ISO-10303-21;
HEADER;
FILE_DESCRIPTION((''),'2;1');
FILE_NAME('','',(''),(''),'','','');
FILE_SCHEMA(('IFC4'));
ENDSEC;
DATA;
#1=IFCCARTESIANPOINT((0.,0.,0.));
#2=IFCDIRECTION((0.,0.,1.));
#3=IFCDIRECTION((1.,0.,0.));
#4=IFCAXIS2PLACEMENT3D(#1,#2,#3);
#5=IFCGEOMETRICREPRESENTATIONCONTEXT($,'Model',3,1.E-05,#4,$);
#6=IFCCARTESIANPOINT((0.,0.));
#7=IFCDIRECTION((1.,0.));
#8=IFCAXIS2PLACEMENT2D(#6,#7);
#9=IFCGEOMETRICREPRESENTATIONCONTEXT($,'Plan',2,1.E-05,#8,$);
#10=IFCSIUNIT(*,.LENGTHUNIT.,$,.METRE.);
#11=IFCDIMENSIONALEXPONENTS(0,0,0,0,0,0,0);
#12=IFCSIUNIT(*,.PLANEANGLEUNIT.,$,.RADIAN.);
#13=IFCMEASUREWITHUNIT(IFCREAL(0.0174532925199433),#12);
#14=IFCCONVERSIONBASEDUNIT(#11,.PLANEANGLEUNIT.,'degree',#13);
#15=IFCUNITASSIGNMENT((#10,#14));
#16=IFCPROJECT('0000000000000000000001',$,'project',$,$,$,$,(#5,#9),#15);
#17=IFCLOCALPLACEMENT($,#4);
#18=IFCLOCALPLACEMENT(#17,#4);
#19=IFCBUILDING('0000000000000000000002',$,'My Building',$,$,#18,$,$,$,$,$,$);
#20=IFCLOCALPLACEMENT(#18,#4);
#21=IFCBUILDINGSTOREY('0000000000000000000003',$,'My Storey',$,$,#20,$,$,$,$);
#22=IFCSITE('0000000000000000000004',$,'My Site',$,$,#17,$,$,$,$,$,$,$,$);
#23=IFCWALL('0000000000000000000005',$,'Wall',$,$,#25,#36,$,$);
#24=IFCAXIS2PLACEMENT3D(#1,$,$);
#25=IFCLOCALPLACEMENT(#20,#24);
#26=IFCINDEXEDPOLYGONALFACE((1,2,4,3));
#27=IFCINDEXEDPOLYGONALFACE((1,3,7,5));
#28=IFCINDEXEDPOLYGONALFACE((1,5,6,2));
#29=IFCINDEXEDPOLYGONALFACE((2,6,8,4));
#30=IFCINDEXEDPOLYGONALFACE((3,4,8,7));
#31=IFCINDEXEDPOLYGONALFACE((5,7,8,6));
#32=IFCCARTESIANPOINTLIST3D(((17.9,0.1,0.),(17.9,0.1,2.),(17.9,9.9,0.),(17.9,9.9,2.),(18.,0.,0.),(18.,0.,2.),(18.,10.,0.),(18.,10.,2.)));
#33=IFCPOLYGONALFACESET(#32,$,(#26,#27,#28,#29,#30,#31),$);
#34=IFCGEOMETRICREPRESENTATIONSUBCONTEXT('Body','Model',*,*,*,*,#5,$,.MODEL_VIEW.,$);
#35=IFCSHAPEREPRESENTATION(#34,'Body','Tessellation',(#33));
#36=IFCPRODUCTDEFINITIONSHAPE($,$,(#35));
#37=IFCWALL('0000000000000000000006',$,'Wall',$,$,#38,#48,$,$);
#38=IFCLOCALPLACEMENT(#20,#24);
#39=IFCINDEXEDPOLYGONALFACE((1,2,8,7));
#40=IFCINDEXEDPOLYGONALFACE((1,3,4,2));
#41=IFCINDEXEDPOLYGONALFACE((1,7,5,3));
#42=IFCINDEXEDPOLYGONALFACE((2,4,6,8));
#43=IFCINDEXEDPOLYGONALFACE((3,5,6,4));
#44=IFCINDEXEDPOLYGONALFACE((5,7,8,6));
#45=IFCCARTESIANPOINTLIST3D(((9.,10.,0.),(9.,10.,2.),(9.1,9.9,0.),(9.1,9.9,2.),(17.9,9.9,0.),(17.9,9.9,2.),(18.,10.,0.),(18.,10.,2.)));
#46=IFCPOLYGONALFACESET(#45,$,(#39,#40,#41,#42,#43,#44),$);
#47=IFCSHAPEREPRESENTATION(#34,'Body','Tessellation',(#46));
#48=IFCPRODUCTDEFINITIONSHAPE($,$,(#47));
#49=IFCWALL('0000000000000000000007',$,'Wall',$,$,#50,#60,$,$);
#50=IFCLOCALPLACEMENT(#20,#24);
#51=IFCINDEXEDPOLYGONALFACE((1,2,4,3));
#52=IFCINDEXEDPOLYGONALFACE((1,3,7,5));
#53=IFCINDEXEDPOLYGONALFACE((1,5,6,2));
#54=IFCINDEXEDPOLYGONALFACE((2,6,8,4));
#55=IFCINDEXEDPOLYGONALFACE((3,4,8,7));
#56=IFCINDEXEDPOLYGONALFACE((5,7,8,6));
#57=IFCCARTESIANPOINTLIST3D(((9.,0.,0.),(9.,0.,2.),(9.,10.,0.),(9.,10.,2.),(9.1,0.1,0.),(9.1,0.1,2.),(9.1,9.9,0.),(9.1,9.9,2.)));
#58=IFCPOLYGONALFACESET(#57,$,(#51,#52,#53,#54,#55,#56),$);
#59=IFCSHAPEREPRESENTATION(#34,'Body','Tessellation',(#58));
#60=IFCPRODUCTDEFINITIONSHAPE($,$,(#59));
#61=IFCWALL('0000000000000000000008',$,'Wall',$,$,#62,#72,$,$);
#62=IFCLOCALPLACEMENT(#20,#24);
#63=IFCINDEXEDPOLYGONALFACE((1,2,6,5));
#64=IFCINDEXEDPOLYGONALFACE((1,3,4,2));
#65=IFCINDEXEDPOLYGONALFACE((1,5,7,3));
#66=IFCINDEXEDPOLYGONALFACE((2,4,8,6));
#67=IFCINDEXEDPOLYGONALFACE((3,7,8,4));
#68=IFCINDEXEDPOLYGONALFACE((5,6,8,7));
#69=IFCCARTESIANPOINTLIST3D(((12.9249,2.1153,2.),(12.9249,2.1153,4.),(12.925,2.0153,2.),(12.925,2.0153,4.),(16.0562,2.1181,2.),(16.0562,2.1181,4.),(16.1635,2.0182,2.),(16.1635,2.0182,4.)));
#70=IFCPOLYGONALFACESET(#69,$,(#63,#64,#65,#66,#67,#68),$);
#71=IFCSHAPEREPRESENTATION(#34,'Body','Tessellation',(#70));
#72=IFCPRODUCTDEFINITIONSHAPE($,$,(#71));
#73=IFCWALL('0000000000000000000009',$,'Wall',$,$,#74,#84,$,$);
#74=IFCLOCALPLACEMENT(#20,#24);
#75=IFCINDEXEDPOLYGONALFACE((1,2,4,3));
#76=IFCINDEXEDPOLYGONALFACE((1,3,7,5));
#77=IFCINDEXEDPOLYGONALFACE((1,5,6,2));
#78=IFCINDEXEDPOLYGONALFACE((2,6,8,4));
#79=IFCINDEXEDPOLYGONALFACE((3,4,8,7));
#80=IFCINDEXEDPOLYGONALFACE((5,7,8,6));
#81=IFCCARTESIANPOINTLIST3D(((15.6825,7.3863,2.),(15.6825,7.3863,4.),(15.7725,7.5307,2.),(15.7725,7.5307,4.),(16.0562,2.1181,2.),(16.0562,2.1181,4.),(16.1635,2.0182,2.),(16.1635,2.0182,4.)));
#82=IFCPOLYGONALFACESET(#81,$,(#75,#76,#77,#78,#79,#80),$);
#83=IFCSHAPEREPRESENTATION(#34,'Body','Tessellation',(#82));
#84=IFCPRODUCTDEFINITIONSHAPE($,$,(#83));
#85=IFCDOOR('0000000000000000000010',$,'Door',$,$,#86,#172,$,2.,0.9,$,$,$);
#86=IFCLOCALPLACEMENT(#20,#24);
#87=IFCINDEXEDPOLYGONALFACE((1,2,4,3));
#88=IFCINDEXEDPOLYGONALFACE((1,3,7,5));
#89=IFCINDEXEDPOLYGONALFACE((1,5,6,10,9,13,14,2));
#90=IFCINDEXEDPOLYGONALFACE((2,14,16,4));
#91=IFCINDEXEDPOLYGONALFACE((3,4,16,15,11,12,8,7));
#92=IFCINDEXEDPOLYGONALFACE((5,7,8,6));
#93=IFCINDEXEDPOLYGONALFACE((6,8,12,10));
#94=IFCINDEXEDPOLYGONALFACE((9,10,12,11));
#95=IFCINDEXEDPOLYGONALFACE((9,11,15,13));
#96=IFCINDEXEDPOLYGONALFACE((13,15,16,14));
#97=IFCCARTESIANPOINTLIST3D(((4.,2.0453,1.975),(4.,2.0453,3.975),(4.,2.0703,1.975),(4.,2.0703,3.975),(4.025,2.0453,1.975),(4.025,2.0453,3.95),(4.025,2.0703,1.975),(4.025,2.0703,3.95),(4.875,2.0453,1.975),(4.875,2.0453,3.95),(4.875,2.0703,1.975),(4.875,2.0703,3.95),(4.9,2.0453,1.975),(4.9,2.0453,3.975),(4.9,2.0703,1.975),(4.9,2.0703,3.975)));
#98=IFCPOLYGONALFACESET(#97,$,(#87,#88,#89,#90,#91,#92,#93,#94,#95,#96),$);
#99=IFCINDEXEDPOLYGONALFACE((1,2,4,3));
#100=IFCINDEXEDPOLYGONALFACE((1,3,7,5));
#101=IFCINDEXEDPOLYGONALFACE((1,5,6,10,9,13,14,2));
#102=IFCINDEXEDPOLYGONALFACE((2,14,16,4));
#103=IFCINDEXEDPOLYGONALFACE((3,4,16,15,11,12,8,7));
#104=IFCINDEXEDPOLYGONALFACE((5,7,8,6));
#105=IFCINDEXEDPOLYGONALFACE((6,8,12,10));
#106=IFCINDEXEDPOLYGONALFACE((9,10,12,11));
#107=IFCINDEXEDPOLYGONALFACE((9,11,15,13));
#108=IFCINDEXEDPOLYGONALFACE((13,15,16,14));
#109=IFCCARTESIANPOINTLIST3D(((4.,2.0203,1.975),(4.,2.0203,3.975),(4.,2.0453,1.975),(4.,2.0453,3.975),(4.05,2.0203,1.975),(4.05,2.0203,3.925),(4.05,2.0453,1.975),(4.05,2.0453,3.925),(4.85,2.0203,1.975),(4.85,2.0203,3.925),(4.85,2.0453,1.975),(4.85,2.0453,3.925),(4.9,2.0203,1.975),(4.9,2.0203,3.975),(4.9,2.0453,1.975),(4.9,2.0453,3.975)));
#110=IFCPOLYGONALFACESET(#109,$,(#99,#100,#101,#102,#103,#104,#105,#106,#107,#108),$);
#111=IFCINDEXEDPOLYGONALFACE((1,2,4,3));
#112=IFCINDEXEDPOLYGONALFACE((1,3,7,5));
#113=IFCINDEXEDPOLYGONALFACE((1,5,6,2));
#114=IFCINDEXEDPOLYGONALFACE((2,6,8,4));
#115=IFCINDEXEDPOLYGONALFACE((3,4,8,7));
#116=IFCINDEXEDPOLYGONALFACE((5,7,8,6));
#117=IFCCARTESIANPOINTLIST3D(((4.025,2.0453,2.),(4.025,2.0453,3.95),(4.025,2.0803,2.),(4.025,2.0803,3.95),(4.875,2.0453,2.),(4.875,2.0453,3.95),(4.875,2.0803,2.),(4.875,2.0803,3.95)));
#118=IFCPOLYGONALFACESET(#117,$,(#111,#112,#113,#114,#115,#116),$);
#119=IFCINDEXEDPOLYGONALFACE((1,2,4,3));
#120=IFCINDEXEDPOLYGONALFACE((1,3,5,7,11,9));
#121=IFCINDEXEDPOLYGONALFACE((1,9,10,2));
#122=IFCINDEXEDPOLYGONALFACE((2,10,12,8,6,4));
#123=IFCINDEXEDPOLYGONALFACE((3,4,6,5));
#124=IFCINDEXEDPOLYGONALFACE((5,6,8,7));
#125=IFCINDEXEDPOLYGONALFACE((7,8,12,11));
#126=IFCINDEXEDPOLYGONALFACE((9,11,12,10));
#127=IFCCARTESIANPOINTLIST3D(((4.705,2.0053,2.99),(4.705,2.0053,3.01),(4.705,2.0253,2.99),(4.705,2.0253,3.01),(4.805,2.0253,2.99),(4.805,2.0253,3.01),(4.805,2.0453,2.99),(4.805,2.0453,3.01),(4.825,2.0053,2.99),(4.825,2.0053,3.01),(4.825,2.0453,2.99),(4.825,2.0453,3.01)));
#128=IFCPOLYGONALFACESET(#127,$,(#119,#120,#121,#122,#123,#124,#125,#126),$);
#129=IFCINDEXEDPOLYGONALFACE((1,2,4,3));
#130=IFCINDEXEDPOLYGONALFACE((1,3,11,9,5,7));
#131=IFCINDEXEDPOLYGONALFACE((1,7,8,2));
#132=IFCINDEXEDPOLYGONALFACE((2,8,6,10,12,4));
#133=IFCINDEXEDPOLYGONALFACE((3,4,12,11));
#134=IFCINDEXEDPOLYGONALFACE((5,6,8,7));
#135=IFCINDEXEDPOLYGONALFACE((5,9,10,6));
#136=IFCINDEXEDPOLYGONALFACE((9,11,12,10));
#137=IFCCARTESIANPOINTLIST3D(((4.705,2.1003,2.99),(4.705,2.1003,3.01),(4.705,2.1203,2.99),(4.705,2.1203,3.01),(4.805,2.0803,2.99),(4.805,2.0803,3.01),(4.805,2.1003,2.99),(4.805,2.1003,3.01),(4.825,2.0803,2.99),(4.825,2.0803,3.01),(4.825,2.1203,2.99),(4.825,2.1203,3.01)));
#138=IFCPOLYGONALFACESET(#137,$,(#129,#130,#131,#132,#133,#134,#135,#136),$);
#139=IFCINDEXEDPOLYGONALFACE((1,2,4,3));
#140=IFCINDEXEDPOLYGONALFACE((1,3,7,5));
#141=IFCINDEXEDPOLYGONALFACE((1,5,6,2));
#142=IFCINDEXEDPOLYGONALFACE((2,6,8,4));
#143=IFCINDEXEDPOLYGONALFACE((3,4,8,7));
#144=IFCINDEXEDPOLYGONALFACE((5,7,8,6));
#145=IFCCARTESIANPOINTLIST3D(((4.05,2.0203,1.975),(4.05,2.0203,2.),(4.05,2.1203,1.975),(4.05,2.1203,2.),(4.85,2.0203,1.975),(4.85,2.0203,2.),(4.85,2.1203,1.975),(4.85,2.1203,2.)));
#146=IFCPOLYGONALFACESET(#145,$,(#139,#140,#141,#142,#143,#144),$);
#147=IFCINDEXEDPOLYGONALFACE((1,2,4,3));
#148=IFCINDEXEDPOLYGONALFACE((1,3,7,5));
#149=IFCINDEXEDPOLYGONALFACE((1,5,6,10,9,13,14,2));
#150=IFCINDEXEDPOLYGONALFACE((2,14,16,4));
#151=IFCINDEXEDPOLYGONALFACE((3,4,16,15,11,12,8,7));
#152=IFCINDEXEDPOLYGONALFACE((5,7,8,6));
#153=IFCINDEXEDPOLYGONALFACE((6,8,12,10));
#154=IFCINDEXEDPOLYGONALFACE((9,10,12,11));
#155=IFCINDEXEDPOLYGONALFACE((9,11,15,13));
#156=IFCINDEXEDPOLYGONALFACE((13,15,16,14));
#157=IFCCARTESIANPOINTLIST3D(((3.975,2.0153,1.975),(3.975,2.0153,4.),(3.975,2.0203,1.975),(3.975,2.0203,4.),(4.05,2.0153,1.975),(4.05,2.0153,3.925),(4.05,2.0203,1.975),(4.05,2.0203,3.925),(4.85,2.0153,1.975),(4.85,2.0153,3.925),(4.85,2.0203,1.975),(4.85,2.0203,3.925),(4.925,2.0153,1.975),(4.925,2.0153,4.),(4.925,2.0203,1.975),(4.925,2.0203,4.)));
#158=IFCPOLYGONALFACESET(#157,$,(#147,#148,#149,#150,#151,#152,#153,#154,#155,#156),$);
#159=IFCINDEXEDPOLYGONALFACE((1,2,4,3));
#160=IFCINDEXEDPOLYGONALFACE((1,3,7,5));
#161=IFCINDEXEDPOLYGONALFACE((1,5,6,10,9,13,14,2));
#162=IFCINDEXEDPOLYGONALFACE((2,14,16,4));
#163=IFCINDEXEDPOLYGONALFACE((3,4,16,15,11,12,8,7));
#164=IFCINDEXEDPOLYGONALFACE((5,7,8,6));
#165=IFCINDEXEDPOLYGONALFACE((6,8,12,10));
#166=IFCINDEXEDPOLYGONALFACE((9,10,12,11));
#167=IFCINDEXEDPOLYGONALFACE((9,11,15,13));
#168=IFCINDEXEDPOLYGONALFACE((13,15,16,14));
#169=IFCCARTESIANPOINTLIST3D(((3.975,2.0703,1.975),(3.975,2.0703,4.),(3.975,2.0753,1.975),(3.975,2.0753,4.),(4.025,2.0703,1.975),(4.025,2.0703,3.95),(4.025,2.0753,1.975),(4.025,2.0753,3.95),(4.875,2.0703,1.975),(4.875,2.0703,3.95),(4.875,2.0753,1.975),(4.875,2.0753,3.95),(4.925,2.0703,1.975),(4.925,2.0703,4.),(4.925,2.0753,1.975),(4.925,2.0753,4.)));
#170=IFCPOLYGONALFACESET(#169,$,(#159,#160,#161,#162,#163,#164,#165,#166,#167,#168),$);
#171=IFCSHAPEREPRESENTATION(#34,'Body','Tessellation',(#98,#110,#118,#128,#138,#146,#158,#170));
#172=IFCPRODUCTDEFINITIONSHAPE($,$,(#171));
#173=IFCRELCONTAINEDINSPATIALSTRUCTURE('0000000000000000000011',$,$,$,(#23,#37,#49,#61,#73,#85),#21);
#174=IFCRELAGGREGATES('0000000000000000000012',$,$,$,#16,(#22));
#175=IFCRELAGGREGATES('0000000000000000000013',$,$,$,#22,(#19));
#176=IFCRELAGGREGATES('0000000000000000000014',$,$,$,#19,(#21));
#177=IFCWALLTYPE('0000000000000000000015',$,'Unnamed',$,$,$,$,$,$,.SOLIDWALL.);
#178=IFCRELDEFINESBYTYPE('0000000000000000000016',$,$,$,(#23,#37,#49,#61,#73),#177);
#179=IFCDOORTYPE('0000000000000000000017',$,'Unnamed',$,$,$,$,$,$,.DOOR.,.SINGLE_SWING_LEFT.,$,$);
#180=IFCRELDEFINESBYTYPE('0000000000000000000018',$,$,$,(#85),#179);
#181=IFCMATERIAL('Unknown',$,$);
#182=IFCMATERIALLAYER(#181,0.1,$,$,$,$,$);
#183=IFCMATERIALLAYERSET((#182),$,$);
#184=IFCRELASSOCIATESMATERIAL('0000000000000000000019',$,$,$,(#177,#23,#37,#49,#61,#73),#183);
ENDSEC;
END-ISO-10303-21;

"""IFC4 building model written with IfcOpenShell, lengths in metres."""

from ifc_helpers import new_model, entity, si_unit, converted_unit, frame, origin_with_axes, origin_2d_with_axis, place, context, subcontext, project, spatial, line, indexed_curve, outline, extrude, clip, halfspace, shape, source, transform, mapped, material, layer, layer_set, layer_usage, type_object, type_shapes, element, save


model = new_model("IFC4")

# Units and contexts
model_context = context("Model", 3, precision=1e-05, world=origin_with_axes())
plan_context = context("Plan", 2, precision=1e-05, world=origin_2d_with_axis())
body_context_1 = subcontext(model_context, "Body", "Model", "MODEL_VIEW")
body_context_2 = subcontext(plan_context, "Body", "Plan", "PLAN_VIEW")
ifc_project = project(units=[si_unit("LENGTHUNIT", "METRE"), converted_unit("PLANEANGLEUNIT", "degree", entity("IfcReal", 0.0174532925199433), si_unit("PLANEANGLEUNIT", "RADIAN"), dimensions=[0, 0, 0, 0, 0, 0, 0])], contexts=[model_context, plan_context])

# Site, building, storey
site_placement = place(None, origin_with_axes())
site = spatial("IfcSite", under=ifc_project, at=site_placement, Name="My Site")
building_placement = place(site_placement, origin_with_axes())
building = spatial("IfcBuilding", under=site, at=building_placement, Name="My Building")
storey_placement = place(building_placement, origin_with_axes())
storey = spatial("IfcBuildingStorey", under=building, at=storey_placement, Name="My Storey")

# Shared definitions
ifc_material = material(Name="Unknown")

# Walls
ifc_layer_1 = layer(ifc_material, 0.1)
ifc_layer_set_1 = layer_set([ifc_layer_1])
wall_type = type_object("IfcWallType", Name="Unnamed", PredefinedType="SOLIDWALL", material=ifc_layer_set_1)
ifc_layer_usage_1 = layer_usage(ifc_layer_set_1, "AXIS2", "POSITIVE", 0.0)
wall_1_placement = place(storey_placement, frame((18.0, 0.0, 0.0), z_axis=(0.0, 0.0, 1.0), x_axis=(0.0, 1.0, 0.0)))
element("IfcWall", 1, at=wall_1_placement, inside=storey, type_object=wall_type, material=ifc_layer_usage_1, Name="Wall", context=body_context_1, shape_type="Clipping", body=[
    clip(clip(extrude(outline(indexed_curve([(0.0, 0.0), (0.0, 0.1), (10.0, 0.1), (10.0, 0.0), (0.0, 0.0)], self_intersect=False)), origin_with_axes(), (0.0, 0.0, 1.0), 2.0), halfspace(frame((10.0, 0.0, 0.0), z_axis=(0.707107, 0.707107, 0.0), x_axis=(0.707107, -0.707107, 0.0)), False)), halfspace(frame((0.0, 0.0, 0.0), z_axis=(-0.707108, 0.707105, 0.0), x_axis=(0.707105, 0.707108, 0.0)), False)),
])
ifc_layer_usage_2 = layer_usage(ifc_layer_set_1, "AXIS2", "POSITIVE", 0.0)
wall_2_placement = place(storey_placement, frame((18.0, 10.0, 0.0), z_axis=(0.0, 0.0, 1.0), x_axis=(-1.0, 0.0, 0.0)))
element("IfcWall", 2, at=wall_2_placement, inside=storey, type_object=wall_type, material=ifc_layer_usage_2, Name="Wall", context=body_context_1, shape_type="Clipping", body=[
    clip(clip(extrude(outline(indexed_curve([(0.0, 0.0), (0.0, 0.1), (9.0, 0.1), (9.0, 0.0), (0.0, 0.0)], self_intersect=False)), origin_with_axes(), (0.0, 0.0, 1.0), 2.0), halfspace(frame((9.0, 0.0, 0.0), z_axis=(0.707107, 0.707107, 0.0), x_axis=(0.707107, -0.707107, 0.0)), False)), halfspace(frame((0.0, 0.0, 0.0), z_axis=(-0.707107, 0.707107, 0.0), x_axis=(0.707107, 0.707107, 0.0)), False)),
])
ifc_layer_usage_3 = layer_usage(ifc_layer_set_1, "AXIS2", "POSITIVE", 0.0)
wall_3_placement = place(storey_placement, frame((9.0, 10.0, 0.0), z_axis=(0.0, 0.0, 1.0), x_axis=(0.0, -1.0, 0.0)))
element("IfcWall", 3, at=wall_3_placement, inside=storey, type_object=wall_type, material=ifc_layer_usage_3, Name="Wall", context=body_context_1, shape_type="Clipping", body=[
    clip(clip(extrude(outline(indexed_curve([(0.0, 0.0), (0.0, 0.1), (10.0, 0.1), (10.0, 0.0), (0.0, 0.0)], self_intersect=False)), origin_with_axes(), (0.0, 0.0, 1.0), 2.0), halfspace(frame((10.0, 0.0, 0.0), z_axis=(0.707108, 0.707105, 0.0), x_axis=(0.707105, -0.707108, 0.0)), False)), halfspace(frame((0.0, 0.0, 0.0), z_axis=(-0.707107, 0.707107, 0.0), x_axis=(0.707107, 0.707107, 0.0)), False)),
])
ifc_layer_usage_4 = layer_usage(ifc_layer_set_1, "AXIS2", "POSITIVE", 0.0)
wall_4_placement = place(storey_placement, frame((12.925, 2.0153, 2.0), z_axis=(0.0, 0.0, 1.0), x_axis=(1.0, 0.000878, 0.0)))
element("IfcWall", 4, at=wall_4_placement, inside=storey, type_object=wall_type, material=ifc_layer_usage_4, Name="Wall", context=body_context_1, shape_type="Clipping", body=[
    clip(extrude(outline(indexed_curve([(0.0, 0.0), (0.0, 0.1), (3.2385, 0.1), (3.2385, 0.0), (0.0, 0.0)], self_intersect=False)), origin_with_axes(), (0.0, 0.0, 1.0), 2.0), halfspace(frame((3.2385, 0.0, -2.0), z_axis=(0.681958, 0.731391, 0.0), x_axis=(0.731391, -0.681958, 0.0)), False)),
])
ifc_layer_usage_5 = layer_usage(ifc_layer_set_1, "AXIS2", "POSITIVE", 0.0)
wall_5_placement = place(storey_placement, frame((16.1635, 2.0182, 2.0), z_axis=(0.0, 0.0, 1.0), x_axis=(-0.070754, 0.997494, 0.0)))
element("IfcWall", 5, at=wall_5_placement, inside=storey, type_object=wall_type, material=ifc_layer_usage_5, Name="Wall", context=body_context_1, shape_type="Clipping", body=[
    clip(clip(extrude(outline(indexed_curve([(0.0, 0.0), (0.0, 0.1), (5.5264, 0.1), (5.5264, 0.0), (0.0, 0.0)], self_intersect=False)), origin_with_axes(), (0.0, 0.0, 1.0), 2.0), halfspace(frame((5.5264, 0.0, -2.0), z_axis=(0.587583, 0.809165, 0.0), x_axis=(0.809164, -0.587582, 0.0)), False)), halfspace(frame((0.0, 0.0, -2.0), z_axis=(-0.681949, 0.7314, 0.0), x_axis=(0.7314, 0.681949, 0.0)), False)),
])

# Door
door_type = type_object("IfcDoorType", Name="Unnamed", OperationType="SINGLE_SWING_LEFT", PredefinedType="DOOR")
shared_shape_1 = source(origin_with_axes(), body_context_1, "Body", "SolidModel", [
    extrude(outline(indexed_curve([(0.0, 0.0), (0.0, 2.0), (0.9, 2.0), (0.9, 0.0), (0.875, 0.0), (0.875, 1.975), (0.025, 1.975), (0.025, 0.0)], segments=[line(1, 2, 3, 4, 5, 6, 7, 8, 1)])), frame((0.0, 0.025, 0.0), z_axis=(0.0, -1.0, 0.0), x_axis=(1.0, 0.0, 0.0)), (0.0, 0.0, -1.0), 0.025),
    extrude(outline(indexed_curve([(0.0, 0.0), (0.0, 2.0), (0.9, 2.0), (0.9, 0.0), (0.85, 0.0), (0.85, 1.95), (0.05, 1.95), (0.05, 0.0)], segments=[line(1, 2, 3, 4, 5, 6, 7, 8, 1)])), frame((0.0, 0.0, 0.0), z_axis=(0.0, -1.0, 0.0), x_axis=(1.0, 0.0, 0.0)), (0.0, 0.0, -1.0), 0.025),
    extrude(outline(indexed_curve([(0.0, 0.0), (0.85, 0.0), (0.85, 0.035), (0.0, 0.035)], segments=[line(1, 2, 3, 4, 1)])), frame((0.025, 0.025, 0.025), z_axis=(0.0, 0.0, 1.0), x_axis=(1.0, 0.0, 0.0)), (0.0, 0.0, 1.0), 1.95),
    extrude(outline(indexed_curve([(0.0, 0.0), (0.0, -0.04), (-0.12, -0.04), (-0.12, -0.02), (-0.02, -0.02), (-0.02, 0.0)], segments=[line(1, 2, 3, 4, 5, 6, 1)])), frame((0.825, 0.025, 1.015), z_axis=(0.0, 0.0, 1.0), x_axis=(1.0, 0.0, 0.0)), (0.0, 0.0, 1.0), 0.02),
    extrude(outline(indexed_curve([(0.0, 0.0), (0.0, 0.04), (-0.12, 0.04), (-0.12, 0.02), (-0.02, 0.02), (-0.02, 0.0)], segments=[line(1, 2, 3, 4, 5, 6, 1)])), frame((0.825, 0.06, 1.015), z_axis=(0.0, 0.0, 1.0), x_axis=(1.0, 0.0, 0.0)), (0.0, 0.0, 1.0), 0.02),
    extrude(outline(indexed_curve([(0.0, 0.0), (0.8, 0.0), (0.8, 0.1), (0.0, 0.1)], segments=[line(1, 2, 3, 4, 1)])), frame((0.05, 0.0, 0.0), z_axis=(0.0, 0.0, 1.0), x_axis=(1.0, 0.0, 0.0)), (0.0, 0.0, 1.0), 0.025),
    extrude(outline(indexed_curve([(0.0, 0.0), (0.0, 2.025), (0.95, 2.025), (0.95, 0.0), (0.875, 0.0), (0.875, 1.95), (0.075, 1.95), (0.075, 0.0)], segments=[line(1, 2, 3, 4, 5, 6, 7, 8, 1)])), frame((-0.025, -0.005, 0.0), z_axis=(0.0, -1.0, 0.0), x_axis=(1.0, 0.0, 0.0)), (0.0, 0.0, -1.0), 0.005),
    extrude(outline(indexed_curve([(0.0, 0.0), (0.0, 2.025), (0.95, 2.025), (0.95, 0.0), (0.9, 0.0), (0.9, 1.975), (0.05, 1.975), (0.05, 0.0)], segments=[line(1, 2, 3, 4, 5, 6, 7, 8, 1)])), frame((-0.025, 0.05, 0.0), z_axis=(0.0, -1.0, 0.0), x_axis=(1.0, 0.0, 0.0)), (0.0, 0.0, -1.0), 0.005),
])
shared_shape_2 = source(origin_with_axes(), body_context_2, "Body", "Curve2D", [
    entity("IfcIndexedPolyCurve", entity("IfcCartesianPointList2D", [[0.0, 0.0], [0.0, 0.05], [0.025, 0.05], [0.025, 0.025], [0.05, 0.025], [0.05, 0.0]]), [entity("IfcLineIndex", [1, 2, 3, 4, 5, 6, 1])]),
    entity("IfcIndexedPolyCurve", entity("IfcCartesianPointList2D", [[0.9, 0.0], [0.9, 0.05], [0.875, 0.05], [0.875, 0.025], [0.85, 0.025], [0.85, 0.0]]), [entity("IfcLineIndex", [1, 2, 3, 4, 5, 6, 1])]),
    entity("IfcTrimmedCurve", entity("IfcEllipse", entity("IfcAxis2Placement2D", entity("IfcCartesianPoint", [0.06, 0.05]), entity("IfcDirection", [1.0, 0.0])), 0.815, 0.85), [entity("IfcCartesianPoint", [0.875, 0.05])], [entity("IfcCartesianPoint", [0.06, 0.9])], True, "CARTESIAN"),
    entity("IfcIndexedPolyCurve", entity("IfcCartesianPointList2D", [[0.025, 0.05], [0.06, 0.05], [0.06, 0.9], [0.025, 0.9]]), [entity("IfcLineIndex", [1, 2, 3, 4, 1])]),
])
type_shapes(door_type, [shared_shape_1, shared_shape_2])
for number, where, z_axis, x_axis, name in (
    (6, (4.0, 2.0203, 1.975), (0.0, 0.0, 1.0), (1.0, 0.0, 0.0), "Door"),
):
    element("IfcDoor", number, at=place(storey_placement, frame(where, z_axis=z_axis, x_axis=x_axis)), inside=storey, type_object=door_type, Name=name, OverallHeight=2.0, OverallWidth=0.9, shapes=[
        shape(body_context_1, "Body", "MappedRepresentation", [mapped(shared_shape_1, transform((0.0, 0.0, 0.0), x_axis=(1.0, 0.0, 0.0), y_axis=(0.0, 1.0, 0.0), z_axis=(0.0, 0.0, 1.0), scale=1.0))]),
        shape(body_context_2, "Body", "MappedRepresentation", [mapped(shared_shape_2, transform((0.0, 0.0, 0.0), x_axis=(1.0, 0.0, 0.0), y_axis=(0.0, 1.0, 0.0), z_axis=(0.0, 0.0, 1.0), scale=1.0))]),
    ])

save(model, "model.ifc")
